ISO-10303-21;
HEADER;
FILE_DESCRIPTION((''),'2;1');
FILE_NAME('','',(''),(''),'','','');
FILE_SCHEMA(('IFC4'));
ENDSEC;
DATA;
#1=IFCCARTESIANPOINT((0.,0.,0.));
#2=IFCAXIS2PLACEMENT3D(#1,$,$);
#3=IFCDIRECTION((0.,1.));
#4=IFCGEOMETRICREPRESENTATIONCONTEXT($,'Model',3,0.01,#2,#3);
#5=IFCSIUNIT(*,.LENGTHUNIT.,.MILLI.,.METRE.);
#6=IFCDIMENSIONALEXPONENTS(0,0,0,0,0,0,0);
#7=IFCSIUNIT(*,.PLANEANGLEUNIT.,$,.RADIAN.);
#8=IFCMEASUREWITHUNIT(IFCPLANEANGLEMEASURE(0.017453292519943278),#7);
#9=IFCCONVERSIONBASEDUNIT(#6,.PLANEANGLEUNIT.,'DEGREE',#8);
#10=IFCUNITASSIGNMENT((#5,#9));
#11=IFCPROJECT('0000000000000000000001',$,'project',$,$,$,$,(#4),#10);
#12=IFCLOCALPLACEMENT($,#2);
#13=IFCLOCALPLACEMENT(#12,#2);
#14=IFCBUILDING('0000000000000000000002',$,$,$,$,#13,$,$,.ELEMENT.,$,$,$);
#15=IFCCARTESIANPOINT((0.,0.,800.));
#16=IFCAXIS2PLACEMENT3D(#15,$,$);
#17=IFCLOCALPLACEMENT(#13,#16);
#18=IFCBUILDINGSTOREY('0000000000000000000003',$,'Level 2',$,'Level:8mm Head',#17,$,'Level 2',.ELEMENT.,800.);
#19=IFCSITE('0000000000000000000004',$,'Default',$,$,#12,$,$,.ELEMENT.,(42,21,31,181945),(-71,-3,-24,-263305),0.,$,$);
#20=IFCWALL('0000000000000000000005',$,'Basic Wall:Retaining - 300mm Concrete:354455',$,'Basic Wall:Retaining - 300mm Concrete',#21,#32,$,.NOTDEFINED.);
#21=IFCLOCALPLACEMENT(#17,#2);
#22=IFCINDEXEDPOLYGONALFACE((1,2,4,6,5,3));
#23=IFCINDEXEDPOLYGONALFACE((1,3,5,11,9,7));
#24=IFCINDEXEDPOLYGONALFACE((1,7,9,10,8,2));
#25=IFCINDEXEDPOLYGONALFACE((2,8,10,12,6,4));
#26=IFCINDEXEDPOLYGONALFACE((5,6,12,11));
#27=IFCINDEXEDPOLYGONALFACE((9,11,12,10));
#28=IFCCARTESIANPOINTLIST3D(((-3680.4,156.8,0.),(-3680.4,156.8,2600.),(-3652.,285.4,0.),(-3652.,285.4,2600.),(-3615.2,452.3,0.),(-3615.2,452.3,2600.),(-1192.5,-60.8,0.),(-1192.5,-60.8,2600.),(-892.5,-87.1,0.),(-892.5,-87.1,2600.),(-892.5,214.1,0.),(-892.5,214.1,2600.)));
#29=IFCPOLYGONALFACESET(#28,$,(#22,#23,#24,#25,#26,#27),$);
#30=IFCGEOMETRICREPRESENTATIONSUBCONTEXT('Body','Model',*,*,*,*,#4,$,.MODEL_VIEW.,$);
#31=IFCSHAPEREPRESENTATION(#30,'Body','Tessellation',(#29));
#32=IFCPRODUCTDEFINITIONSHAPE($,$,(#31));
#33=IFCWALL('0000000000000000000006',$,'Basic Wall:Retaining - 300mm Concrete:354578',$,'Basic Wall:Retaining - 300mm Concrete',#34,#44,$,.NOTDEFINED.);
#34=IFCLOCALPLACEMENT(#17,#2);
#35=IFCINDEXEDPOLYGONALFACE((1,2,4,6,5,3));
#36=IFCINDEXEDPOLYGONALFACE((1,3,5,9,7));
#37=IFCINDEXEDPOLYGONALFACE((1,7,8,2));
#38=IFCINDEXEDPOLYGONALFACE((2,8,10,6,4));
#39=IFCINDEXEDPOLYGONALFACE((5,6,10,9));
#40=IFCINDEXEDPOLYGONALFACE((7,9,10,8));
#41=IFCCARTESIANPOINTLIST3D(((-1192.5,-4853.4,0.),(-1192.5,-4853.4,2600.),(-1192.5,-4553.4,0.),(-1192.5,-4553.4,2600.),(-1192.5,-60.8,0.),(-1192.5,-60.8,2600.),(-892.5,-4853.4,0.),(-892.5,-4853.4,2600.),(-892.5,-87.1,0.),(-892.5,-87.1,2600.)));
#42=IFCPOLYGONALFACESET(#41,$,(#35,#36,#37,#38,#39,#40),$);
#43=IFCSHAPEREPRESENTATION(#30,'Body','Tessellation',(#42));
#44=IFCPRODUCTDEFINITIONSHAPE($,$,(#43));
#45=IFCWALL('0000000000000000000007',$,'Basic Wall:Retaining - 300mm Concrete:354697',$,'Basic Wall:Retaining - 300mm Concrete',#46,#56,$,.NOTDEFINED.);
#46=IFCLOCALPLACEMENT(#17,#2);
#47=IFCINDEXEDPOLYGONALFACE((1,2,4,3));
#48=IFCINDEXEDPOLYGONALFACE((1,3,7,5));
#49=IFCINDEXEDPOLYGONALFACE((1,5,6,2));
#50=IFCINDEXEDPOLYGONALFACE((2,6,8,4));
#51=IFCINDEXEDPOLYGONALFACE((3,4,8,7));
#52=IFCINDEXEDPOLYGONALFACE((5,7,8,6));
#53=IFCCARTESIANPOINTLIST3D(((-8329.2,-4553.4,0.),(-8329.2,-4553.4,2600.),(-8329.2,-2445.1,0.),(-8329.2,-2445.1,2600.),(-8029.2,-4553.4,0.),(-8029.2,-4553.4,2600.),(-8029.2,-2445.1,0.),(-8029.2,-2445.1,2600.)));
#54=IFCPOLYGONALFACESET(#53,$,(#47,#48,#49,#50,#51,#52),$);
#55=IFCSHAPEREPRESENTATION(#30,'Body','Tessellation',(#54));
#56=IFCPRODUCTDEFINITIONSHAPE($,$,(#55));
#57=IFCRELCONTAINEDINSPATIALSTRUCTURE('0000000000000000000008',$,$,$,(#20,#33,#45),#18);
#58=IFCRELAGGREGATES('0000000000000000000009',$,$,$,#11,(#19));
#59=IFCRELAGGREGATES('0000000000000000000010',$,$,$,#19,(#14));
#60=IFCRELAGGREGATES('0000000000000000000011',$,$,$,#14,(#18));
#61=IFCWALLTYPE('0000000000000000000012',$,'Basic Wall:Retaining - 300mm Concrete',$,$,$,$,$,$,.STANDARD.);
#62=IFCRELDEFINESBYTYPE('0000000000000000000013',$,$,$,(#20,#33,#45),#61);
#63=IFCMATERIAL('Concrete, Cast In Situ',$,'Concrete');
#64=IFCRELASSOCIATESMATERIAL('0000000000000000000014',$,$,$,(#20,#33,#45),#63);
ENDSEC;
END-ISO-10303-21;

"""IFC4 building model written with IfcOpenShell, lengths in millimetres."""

from ifc_helpers import new_model, entity, si_unit, converted_unit, direction, frame, origin, place, context, subcontext, project, spatial, indexed_curve, outline, extrude, material, type_object, element, save


model = new_model("IFC4")

# Units and contexts
model_context = context("Model", 3, precision=0.01, world=origin(), true_north=direction((0.0, 1.0)))
body_context = subcontext(model_context, "Body", "Model", "MODEL_VIEW")
ifc_project = project(units=[si_unit("LENGTHUNIT", "METRE", prefix="MILLI"), converted_unit("PLANEANGLEUNIT", "DEGREE", entity("IfcPlaneAngleMeasure", 0.017453292519943278), si_unit("PLANEANGLEUNIT", "RADIAN"), dimensions=[0, 0, 0, 0, 0, 0, 0])], contexts=[model_context])

# Site, building, storey
site_placement = place(None, origin())
site = spatial("IfcSite", under=ifc_project, at=site_placement, Name="Default", CompositionType="ELEMENT", RefLatitude=(42, 21, 31, 181945), RefLongitude=(-71, -3, -24, -263305), RefElevation=0.0)
building_placement = place(site_placement, origin())
building = spatial("IfcBuilding", under=site, at=building_placement, CompositionType="ELEMENT")
storey_placement = place(building_placement, frame((0.0, 0.0, 800.0)))
storey = spatial("IfcBuildingStorey", under=building, at=storey_placement, Name="Level 2", ObjectType="Level:8mm Head", LongName="Level 2", CompositionType="ELEMENT", Elevation=800.0)

# Shared definitions
ifc_material_1 = material(Name="Concrete, Cast In Situ", Category="Concrete")

# Walls
wall_type = type_object("IfcWallType", Name="Basic Wall:Retaining - 300mm Concrete", PredefinedType="STANDARD")
wall_1_placement = place(storey_placement, frame((-3667.3, 306.3, 0.0), z_axis=(0.0, 0.0, 1.0), x_axis=(0.996195, -0.087156, 0.0)))
element("IfcWall", 1, at=wall_1_placement, inside=storey, type_object=wall_type, material=ifc_material_1, Name="Basic Wall:Retaining - 300mm Concrete:354455", ObjectType="Basic Wall:Retaining - 300mm Concrete", PredefinedType="NOTDEFINED", context=body_context, shape_type="SweptSolid", body=[
    extrude(outline(indexed_curve([(2798.6, -150.0), (2772.3, 150.0), (39.2, 150.0), (17.1, -19.4), (0.0, -150.0), (2497.4, -150.0), (2798.6, -150.0)], self_intersect=False)), origin(), (0.0, 0.0, 1.0), 2600.0),
])
wall_2_placement = place(storey_placement, frame((-1042.5, -60.8, 0.0), z_axis=(0.0, 0.0, 1.0), x_axis=(0.0, -1.0, 0.0)))
element("IfcWall", 2, at=wall_2_placement, inside=storey, type_object=wall_type, material=ifc_material_1, Name="Basic Wall:Retaining - 300mm Concrete:354578", ObjectType="Basic Wall:Retaining - 300mm Concrete", PredefinedType="NOTDEFINED", context=body_context, shape_type="SweptSolid", body=[
    extrude(outline(indexed_curve([(4792.6, -150.0), (4792.6, 150.0), (26.2, 150.0), (0.0, -150.0), (4492.6, -150.0), (4792.6, -150.0)], self_intersect=False)), origin(), (0.0, 0.0, 1.0), 2600.0),
])
wall_3_placement = place(storey_placement, frame((-8179.2, -4553.4, 0.0), z_axis=(0.0, 0.0, 1.0), x_axis=(0.0, 1.0, 0.0)))
element("IfcWall", 3, at=wall_3_placement, inside=storey, type_object=wall_type, material=ifc_material_1, Name="Basic Wall:Retaining - 300mm Concrete:354697", ObjectType="Basic Wall:Retaining - 300mm Concrete", PredefinedType="NOTDEFINED", context=body_context, shape_type="SweptSolid", body=[
    extrude(outline(indexed_curve([(2108.3, 150.0), (0.0, 150.0), (0.0, -150.0), (2108.3, -150.0), (2108.3, 150.0)], self_intersect=False)), origin(), (0.0, 0.0, 1.0), 2600.0),
])

save(model, "model.ifc")
